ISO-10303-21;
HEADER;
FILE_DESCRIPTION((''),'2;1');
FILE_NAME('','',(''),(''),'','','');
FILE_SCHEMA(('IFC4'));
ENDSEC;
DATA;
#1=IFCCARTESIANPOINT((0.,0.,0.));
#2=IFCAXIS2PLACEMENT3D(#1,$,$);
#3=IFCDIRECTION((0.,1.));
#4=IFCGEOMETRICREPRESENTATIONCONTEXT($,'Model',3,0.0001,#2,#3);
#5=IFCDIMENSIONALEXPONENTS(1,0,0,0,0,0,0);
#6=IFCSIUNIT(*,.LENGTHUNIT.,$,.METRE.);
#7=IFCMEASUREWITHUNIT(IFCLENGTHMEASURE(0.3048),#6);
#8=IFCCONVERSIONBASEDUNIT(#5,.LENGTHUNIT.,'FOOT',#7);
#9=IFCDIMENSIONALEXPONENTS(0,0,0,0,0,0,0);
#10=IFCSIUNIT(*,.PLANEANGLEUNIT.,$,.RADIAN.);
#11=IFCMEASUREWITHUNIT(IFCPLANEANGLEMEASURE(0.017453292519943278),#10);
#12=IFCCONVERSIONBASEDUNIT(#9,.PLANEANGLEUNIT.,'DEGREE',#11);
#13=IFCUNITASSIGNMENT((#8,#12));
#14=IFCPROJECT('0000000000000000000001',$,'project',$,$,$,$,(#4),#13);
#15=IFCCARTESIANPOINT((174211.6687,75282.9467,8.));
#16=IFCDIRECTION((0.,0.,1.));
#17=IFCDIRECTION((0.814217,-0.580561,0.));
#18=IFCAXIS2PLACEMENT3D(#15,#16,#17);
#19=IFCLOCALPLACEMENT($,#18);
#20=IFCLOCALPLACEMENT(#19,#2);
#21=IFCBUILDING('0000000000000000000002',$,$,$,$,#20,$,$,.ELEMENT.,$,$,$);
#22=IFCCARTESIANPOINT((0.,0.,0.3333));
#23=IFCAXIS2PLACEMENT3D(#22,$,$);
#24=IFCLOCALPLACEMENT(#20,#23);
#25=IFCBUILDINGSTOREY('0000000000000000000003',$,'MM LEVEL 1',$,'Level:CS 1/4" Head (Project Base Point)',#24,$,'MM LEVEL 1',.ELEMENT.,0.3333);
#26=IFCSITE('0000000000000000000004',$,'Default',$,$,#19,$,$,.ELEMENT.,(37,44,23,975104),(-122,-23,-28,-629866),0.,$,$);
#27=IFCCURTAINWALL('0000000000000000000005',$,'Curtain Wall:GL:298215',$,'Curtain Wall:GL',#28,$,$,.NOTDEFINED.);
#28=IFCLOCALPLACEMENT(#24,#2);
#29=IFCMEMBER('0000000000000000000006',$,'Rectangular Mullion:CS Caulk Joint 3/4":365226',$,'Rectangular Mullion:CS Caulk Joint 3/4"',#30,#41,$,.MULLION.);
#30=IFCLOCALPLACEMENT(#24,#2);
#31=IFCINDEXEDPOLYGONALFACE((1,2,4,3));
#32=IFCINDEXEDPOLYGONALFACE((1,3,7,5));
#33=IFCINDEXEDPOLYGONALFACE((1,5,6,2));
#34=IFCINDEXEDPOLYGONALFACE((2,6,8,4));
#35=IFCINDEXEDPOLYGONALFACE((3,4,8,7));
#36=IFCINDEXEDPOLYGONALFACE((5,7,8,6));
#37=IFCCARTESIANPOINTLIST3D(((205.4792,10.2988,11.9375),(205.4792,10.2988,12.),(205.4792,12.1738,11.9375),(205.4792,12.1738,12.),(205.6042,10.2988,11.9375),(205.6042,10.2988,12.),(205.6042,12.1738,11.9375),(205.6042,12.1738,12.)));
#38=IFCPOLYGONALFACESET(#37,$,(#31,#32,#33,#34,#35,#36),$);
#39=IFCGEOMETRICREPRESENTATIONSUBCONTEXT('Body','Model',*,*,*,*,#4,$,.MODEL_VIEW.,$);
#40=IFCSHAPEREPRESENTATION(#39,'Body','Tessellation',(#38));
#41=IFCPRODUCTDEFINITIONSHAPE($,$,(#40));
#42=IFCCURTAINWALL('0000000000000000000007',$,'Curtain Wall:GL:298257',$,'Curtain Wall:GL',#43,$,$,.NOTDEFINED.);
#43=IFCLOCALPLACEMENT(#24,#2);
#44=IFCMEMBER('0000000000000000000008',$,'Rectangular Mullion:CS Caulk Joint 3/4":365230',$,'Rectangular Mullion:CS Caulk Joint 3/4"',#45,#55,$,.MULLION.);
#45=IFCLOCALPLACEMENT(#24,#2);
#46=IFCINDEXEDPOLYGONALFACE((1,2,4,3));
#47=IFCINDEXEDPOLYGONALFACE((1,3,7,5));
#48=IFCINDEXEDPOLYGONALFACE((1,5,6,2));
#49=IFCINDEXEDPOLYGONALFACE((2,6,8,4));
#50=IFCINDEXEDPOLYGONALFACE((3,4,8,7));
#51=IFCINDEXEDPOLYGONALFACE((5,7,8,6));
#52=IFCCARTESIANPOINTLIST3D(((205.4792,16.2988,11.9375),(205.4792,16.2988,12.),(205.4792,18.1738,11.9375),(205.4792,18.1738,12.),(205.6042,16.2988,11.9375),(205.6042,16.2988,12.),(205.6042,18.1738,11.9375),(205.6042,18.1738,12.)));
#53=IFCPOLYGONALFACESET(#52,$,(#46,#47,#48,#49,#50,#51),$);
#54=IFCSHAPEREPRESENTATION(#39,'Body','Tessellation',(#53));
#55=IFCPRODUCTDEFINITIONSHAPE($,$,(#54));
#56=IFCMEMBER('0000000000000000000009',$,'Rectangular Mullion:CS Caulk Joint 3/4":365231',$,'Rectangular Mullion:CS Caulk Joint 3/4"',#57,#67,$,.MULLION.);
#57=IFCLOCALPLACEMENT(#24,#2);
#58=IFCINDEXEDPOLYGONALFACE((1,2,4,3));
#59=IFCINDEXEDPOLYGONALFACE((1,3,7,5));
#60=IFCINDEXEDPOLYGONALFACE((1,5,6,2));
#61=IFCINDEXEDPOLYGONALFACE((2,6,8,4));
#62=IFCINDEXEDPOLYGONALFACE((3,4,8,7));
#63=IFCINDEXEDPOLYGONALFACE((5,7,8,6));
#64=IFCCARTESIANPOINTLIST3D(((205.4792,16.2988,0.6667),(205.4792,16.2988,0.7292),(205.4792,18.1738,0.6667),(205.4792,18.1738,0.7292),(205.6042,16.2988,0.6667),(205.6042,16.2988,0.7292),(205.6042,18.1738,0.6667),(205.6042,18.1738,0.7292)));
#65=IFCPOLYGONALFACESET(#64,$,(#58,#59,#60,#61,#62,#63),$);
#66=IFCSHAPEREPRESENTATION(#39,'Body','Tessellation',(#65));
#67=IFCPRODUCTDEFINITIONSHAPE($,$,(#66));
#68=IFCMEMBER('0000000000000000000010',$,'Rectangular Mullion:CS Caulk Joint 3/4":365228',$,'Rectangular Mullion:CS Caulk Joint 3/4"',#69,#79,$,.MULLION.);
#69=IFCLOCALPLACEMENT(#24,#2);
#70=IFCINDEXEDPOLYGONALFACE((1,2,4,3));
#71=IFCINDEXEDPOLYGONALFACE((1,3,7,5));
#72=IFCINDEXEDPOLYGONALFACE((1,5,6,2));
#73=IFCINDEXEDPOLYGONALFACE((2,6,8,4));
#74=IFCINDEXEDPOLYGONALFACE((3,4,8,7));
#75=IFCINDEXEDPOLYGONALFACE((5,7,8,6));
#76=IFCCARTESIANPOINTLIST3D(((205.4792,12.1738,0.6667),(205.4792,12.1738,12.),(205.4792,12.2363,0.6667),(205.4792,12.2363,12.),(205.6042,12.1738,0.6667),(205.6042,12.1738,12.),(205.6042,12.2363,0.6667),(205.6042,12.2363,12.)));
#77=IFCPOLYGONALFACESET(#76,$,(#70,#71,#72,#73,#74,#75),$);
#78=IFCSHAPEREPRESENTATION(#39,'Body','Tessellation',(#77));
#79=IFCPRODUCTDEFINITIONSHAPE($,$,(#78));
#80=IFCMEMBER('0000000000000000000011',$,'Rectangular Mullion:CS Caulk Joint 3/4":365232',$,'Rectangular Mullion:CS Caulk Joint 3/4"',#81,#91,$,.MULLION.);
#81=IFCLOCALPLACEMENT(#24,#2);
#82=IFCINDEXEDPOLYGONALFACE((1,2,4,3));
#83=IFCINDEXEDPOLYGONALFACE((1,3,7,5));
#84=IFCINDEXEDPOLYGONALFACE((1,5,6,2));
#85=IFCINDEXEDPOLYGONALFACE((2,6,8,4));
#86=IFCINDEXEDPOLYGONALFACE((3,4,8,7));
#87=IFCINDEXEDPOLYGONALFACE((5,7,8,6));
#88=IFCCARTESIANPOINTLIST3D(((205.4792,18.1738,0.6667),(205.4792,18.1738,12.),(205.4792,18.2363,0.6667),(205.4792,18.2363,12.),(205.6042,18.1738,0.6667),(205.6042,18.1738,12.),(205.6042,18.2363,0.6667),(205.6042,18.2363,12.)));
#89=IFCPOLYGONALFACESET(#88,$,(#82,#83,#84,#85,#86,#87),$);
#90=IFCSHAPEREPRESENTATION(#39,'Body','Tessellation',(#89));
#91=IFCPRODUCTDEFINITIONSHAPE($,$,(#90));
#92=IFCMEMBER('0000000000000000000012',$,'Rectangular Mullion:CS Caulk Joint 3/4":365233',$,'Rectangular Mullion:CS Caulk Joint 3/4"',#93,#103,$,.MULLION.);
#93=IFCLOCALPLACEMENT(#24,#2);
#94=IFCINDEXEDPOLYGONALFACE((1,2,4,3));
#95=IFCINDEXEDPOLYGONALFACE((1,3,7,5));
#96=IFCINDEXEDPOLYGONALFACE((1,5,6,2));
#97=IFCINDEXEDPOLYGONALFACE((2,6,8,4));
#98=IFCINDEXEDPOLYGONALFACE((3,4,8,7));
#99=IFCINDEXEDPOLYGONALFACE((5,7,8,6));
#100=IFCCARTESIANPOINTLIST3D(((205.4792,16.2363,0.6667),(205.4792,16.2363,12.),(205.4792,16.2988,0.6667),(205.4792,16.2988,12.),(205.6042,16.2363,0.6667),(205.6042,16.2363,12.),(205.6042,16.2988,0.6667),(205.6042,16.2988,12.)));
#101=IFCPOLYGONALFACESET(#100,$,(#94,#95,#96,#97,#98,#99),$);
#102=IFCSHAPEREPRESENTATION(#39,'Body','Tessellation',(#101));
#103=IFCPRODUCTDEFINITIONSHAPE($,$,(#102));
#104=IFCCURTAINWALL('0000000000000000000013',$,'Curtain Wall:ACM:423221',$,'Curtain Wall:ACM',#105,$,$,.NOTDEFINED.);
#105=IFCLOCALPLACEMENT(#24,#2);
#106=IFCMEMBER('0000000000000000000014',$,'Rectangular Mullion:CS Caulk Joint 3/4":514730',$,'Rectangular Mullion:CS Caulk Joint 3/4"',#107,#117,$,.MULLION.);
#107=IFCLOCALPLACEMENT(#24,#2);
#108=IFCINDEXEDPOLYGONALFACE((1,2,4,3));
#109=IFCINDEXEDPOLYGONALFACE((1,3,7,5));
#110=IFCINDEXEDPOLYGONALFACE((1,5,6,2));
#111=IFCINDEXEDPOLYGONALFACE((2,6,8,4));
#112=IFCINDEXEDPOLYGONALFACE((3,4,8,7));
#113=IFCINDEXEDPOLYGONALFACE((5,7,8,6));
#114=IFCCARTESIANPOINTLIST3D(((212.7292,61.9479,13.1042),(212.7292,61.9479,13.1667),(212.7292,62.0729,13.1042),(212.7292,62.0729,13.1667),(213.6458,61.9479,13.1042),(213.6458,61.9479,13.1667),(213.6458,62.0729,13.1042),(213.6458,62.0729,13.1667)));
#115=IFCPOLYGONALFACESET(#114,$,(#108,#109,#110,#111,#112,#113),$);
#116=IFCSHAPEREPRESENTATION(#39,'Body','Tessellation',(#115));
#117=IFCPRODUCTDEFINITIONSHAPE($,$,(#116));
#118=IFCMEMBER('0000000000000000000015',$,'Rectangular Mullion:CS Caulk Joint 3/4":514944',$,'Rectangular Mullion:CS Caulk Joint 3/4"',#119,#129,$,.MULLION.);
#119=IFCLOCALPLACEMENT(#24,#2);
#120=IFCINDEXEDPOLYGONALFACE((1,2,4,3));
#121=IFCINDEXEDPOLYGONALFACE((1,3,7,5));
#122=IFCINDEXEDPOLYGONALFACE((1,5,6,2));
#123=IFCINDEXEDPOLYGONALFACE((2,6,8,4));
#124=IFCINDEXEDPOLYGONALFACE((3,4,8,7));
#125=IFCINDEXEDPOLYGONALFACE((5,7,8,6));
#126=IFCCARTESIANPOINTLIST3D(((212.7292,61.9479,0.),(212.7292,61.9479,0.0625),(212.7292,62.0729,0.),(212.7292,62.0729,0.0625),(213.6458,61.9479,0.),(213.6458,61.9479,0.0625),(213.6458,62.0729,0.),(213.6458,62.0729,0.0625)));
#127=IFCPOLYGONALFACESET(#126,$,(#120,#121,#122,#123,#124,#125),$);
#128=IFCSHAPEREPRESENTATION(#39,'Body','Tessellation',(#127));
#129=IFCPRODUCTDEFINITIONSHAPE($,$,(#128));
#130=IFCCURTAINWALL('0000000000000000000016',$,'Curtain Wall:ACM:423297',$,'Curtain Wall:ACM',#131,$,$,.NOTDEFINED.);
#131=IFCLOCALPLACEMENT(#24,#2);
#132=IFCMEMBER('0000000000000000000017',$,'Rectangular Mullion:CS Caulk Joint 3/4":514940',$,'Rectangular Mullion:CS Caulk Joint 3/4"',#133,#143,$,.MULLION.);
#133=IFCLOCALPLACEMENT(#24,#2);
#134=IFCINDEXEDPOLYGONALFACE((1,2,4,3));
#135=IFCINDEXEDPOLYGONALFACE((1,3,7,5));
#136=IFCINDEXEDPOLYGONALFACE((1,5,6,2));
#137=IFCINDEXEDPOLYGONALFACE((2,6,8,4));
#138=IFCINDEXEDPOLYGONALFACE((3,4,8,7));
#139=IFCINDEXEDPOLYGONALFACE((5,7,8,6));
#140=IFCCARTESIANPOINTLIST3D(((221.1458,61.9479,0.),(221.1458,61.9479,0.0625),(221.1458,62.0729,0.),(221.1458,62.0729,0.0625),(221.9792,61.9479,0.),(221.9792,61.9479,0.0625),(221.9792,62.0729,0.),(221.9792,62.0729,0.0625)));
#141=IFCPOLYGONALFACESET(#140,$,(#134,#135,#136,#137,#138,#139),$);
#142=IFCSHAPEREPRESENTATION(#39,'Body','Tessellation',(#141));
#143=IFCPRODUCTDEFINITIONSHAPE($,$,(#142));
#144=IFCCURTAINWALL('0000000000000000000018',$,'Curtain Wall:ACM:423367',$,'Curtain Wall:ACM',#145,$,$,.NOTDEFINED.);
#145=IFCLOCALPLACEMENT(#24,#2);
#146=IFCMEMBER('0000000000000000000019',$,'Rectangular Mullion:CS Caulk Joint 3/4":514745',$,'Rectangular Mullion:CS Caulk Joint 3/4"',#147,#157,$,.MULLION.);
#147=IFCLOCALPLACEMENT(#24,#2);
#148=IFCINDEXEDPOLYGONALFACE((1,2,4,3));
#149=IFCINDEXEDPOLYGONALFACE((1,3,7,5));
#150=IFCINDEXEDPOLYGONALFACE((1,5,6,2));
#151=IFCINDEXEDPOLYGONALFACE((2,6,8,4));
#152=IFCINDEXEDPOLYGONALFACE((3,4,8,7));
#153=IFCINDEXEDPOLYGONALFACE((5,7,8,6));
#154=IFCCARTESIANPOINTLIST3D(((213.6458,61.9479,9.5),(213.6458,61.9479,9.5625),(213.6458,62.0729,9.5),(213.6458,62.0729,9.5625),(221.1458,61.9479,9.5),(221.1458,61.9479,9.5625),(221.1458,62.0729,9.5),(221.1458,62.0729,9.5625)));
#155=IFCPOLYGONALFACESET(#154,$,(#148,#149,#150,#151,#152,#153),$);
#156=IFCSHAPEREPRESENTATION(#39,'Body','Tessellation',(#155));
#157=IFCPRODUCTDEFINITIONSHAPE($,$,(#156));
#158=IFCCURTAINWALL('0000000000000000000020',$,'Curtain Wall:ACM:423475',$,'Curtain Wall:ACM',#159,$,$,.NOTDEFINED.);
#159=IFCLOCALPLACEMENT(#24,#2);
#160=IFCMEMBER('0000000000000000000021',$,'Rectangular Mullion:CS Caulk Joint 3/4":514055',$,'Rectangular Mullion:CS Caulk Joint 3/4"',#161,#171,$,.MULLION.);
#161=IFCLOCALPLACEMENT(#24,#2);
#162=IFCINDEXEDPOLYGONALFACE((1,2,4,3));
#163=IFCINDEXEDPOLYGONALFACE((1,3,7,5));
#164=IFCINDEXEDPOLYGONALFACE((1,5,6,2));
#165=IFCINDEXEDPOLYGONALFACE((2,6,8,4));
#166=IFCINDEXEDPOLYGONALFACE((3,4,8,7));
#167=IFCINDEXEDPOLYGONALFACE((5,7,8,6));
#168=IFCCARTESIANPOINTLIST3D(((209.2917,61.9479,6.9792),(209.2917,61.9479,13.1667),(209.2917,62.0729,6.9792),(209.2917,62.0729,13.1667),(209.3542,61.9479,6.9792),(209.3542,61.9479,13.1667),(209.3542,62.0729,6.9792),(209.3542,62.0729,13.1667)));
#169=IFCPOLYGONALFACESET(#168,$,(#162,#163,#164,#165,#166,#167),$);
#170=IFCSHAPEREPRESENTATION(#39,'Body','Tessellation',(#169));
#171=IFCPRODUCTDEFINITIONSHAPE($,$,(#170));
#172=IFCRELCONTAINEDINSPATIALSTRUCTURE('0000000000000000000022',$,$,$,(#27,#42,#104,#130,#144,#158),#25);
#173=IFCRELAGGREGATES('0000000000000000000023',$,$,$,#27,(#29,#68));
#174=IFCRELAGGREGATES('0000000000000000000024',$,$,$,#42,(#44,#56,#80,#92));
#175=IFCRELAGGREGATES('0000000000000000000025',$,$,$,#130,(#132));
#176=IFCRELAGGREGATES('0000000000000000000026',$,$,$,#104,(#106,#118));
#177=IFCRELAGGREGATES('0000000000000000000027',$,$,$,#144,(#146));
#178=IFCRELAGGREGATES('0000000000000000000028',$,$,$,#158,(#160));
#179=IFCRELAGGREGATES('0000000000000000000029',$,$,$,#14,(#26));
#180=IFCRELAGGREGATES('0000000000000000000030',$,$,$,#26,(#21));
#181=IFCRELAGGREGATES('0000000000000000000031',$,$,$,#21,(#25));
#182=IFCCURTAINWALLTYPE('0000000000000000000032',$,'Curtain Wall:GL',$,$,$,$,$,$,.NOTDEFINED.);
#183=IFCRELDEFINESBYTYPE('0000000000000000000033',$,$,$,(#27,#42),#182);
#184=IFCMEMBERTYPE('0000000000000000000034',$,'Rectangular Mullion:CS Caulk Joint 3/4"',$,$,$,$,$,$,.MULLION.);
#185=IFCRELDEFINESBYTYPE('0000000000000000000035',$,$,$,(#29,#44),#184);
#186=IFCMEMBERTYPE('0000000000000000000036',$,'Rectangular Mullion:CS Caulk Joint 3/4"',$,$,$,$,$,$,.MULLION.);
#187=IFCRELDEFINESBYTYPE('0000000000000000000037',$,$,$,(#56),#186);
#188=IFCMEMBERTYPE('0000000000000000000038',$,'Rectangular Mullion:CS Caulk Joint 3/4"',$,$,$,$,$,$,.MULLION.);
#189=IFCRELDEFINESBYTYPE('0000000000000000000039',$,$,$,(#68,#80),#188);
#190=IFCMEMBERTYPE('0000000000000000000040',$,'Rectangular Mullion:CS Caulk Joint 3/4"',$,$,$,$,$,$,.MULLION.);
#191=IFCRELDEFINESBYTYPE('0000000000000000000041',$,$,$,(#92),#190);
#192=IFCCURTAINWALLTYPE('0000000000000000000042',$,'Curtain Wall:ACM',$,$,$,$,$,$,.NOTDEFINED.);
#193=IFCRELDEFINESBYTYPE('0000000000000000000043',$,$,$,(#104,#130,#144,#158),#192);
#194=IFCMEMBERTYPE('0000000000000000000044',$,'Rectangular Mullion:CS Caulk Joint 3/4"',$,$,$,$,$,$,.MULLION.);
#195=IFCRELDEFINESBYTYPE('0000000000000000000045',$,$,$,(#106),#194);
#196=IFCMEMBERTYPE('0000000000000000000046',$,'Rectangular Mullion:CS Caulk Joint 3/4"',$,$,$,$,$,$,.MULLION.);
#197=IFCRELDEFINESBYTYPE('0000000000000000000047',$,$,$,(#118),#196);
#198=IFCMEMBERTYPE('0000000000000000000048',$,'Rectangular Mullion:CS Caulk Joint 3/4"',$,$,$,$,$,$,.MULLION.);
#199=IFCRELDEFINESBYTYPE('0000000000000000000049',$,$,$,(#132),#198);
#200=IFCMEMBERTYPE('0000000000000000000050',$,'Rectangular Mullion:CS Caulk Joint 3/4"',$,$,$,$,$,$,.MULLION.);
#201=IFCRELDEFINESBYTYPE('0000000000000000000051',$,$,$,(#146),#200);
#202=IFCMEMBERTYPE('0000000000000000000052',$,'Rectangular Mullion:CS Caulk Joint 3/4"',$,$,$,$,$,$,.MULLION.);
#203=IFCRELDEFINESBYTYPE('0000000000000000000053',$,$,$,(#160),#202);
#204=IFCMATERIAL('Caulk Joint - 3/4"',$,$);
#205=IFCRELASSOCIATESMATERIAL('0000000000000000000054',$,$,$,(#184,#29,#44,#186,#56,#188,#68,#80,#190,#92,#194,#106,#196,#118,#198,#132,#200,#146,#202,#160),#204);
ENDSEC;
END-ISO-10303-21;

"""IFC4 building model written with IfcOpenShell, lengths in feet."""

from ifc_helpers import new_model, entity, si_unit, converted_unit, direction, frame, origin, place, context, subcontext, project, spatial, indexed_curve, outline, extrude, source, transform, mapped, material, type_object, type_shapes, element, aggregate, save


model = new_model("IFC4")

# Units and contexts
model_context = context("Model", 3, precision=0.0001, world=origin(), true_north=direction((0.0, 1.0)))
body_context = subcontext(model_context, "Body", "Model", "MODEL_VIEW")
ifc_project = project(units=[converted_unit("LENGTHUNIT", "FOOT", entity("IfcLengthMeasure", 0.3048), si_unit("LENGTHUNIT", "METRE"), dimensions=[1, 0, 0, 0, 0, 0, 0]), converted_unit("PLANEANGLEUNIT", "DEGREE", entity("IfcPlaneAngleMeasure", 0.017453292519943278), si_unit("PLANEANGLEUNIT", "RADIAN"), dimensions=[0, 0, 0, 0, 0, 0, 0])], contexts=[model_context])

# Site, building, storey
site_placement = place(None, frame((174211.6687, 75282.9467, 8.0), z_axis=(0.0, 0.0, 1.0), x_axis=(0.814217, -0.580561, 0.0)))
site = spatial("IfcSite", under=ifc_project, at=site_placement, Name="Default", CompositionType="ELEMENT", RefLatitude=(37, 44, 23, 975104), RefLongitude=(-122, -23, -28, -629866), RefElevation=0.0)
building_placement = place(site_placement, origin())
building = spatial("IfcBuilding", under=site, at=building_placement, CompositionType="ELEMENT")
storey_placement = place(building_placement, frame((0.0, 0.0, 0.3333)))
storey = spatial("IfcBuildingStorey", under=building, at=storey_placement, Name="MM LEVEL 1", ObjectType="Level:CS 1/4\" Head (Project Base Point)", LongName="MM LEVEL 1", CompositionType="ELEMENT", Elevation=0.3333)

# Curtain wall, member
curtain_wall_type_1 = type_object("IfcCurtainWallType", Name="Curtain Wall:GL", PredefinedType="NOTDEFINED")
curtain_wall_1_placement = place(storey_placement, frame((0.0, 0.0, -0.3333)))
curtain_wall_1 = element("IfcCurtainWall", 1, at=curtain_wall_1_placement, inside=storey, type_object=curtain_wall_type_1, Name="Curtain Wall:GL:298215", ObjectType="Curtain Wall:GL", PredefinedType="NOTDEFINED")
ifc_material_1 = material(Name="Caulk Joint - 3/4\"")
member_type_1 = type_object("IfcMemberType", Name="Rectangular Mullion:CS Caulk Joint 3/4\"", PredefinedType="MULLION", material=ifc_material_1)
shared_shape_1 = source(origin(), body_context, "Body", "SweptSolid", [
    extrude(outline(indexed_curve([(-0.0625, -0.0312), (0.0625, -0.0312), (0.0625, 0.0312), (-0.0625, 0.0312), (-0.0625, -0.0312)], self_intersect=False)), frame((-0.0312, 0.0625, -1.875), z_axis=(0.0, 0.0, 1.0), x_axis=(0.0, -1.0, 0.0)), (0.0, 0.0, 1.0), 1.875),
])
type_shapes(member_type_1, [shared_shape_1])
member_1_placement = place(curtain_wall_1_placement, frame((205.4792, 12.1738, 12.3333), z_axis=(0.0, 1.0, 0.0), x_axis=(0.0, 0.0, 1.0)))
member_1 = element("IfcMember", 2, at=member_1_placement, type_object=member_type_1, material=ifc_material_1, Name="Rectangular Mullion:CS Caulk Joint 3/4\":365226", ObjectType="Rectangular Mullion:CS Caulk Joint 3/4\"", PredefinedType="MULLION", context=body_context, shape_type="MappedRepresentation", body=[
    mapped(shared_shape_1, transform((0.0, 0.0, 0.0), scale=1.0)),
])

# Curtain wall, members
curtain_wall_2_placement = place(storey_placement, frame((0.0, 0.0, -0.3333)))
curtain_wall_2 = element("IfcCurtainWall", 3, at=curtain_wall_2_placement, inside=storey, type_object=curtain_wall_type_1, Name="Curtain Wall:GL:298257", ObjectType="Curtain Wall:GL", PredefinedType="NOTDEFINED")
member_2_placement = place(curtain_wall_2_placement, frame((205.4792, 18.1738, 12.3333), z_axis=(0.0, 1.0, 0.0), x_axis=(0.0, 0.0, 1.0)))
member_2 = element("IfcMember", 4, at=member_2_placement, type_object=member_type_1, material=ifc_material_1, Name="Rectangular Mullion:CS Caulk Joint 3/4\":365230", ObjectType="Rectangular Mullion:CS Caulk Joint 3/4\"", PredefinedType="MULLION", context=body_context, shape_type="MappedRepresentation", body=[
    mapped(shared_shape_1, transform((0.0, 0.0, 0.0), scale=1.0)),
])
member_type_2 = type_object("IfcMemberType", Name="Rectangular Mullion:CS Caulk Joint 3/4\"", PredefinedType="MULLION", material=ifc_material_1)
shared_shape_2 = source(origin(), body_context, "Body", "SweptSolid", [
    extrude(outline(indexed_curve([(-0.0312, -0.0625), (0.0312, -0.0625), (0.0312, 0.0625), (-0.0312, 0.0625), (-0.0312, -0.0625)], self_intersect=False)), frame((-0.0312, 0.0625, -1.875), z_axis=(0.0, 0.0, 1.0), x_axis=(-1.0, 0.0, 0.0)), (0.0, 0.0, 1.0), 1.875),
])
type_shapes(member_type_2, [shared_shape_2])
member_3_placement = place(curtain_wall_2_placement, frame((205.4792, 16.2988, 1.0), z_axis=(0.0, -1.0, 0.0), x_axis=(0.0, 0.0, -1.0)))
member_3 = element("IfcMember", 5, at=member_3_placement, type_object=member_type_2, material=ifc_material_1, Name="Rectangular Mullion:CS Caulk Joint 3/4\":365231", ObjectType="Rectangular Mullion:CS Caulk Joint 3/4\"", PredefinedType="MULLION", context=body_context, shape_type="MappedRepresentation", body=[
    mapped(shared_shape_2, transform((0.0, 0.0, 0.0), scale=1.0)),
])

# Members
member_type_3 = type_object("IfcMemberType", Name="Rectangular Mullion:CS Caulk Joint 3/4\"", PredefinedType="MULLION", material=ifc_material_1)
shared_shape_3 = source(origin(), body_context, "Body", "SweptSolid", [
    extrude(outline(indexed_curve([(-0.0625, -0.0312), (0.0625, -0.0312), (0.0625, 0.0312), (-0.0625, 0.0312), (-0.0625, -0.0312)], self_intersect=False)), frame((-0.0312, 0.0625, -11.3333), z_axis=(0.0, 0.0, 1.0), x_axis=(0.0, -1.0, 0.0)), (0.0, 0.0, 1.0), 11.3333),
])
type_shapes(member_type_3, [shared_shape_3])
member_4_placement = place(curtain_wall_1_placement, frame((205.4792, 12.2363, 1.0), z_axis=(0.0, 0.0, -1.0), x_axis=(0.0, 1.0, 0.0)))
member_4 = element("IfcMember", 6, at=member_4_placement, type_object=member_type_3, material=ifc_material_1, Name="Rectangular Mullion:CS Caulk Joint 3/4\":365228", ObjectType="Rectangular Mullion:CS Caulk Joint 3/4\"", PredefinedType="MULLION", context=body_context, shape_type="MappedRepresentation", body=[
    mapped(shared_shape_3, transform((0.0, 0.0, 0.0), scale=1.0)),
])
aggregate(curtain_wall_1, [member_1, member_4])
member_5_placement = place(curtain_wall_2_placement, frame((205.4792, 18.2363, 1.0), z_axis=(0.0, 0.0, -1.0), x_axis=(0.0, 1.0, 0.0)))
member_5 = element("IfcMember", 7, at=member_5_placement, type_object=member_type_3, material=ifc_material_1, Name="Rectangular Mullion:CS Caulk Joint 3/4\":365232", ObjectType="Rectangular Mullion:CS Caulk Joint 3/4\"", PredefinedType="MULLION", context=body_context, shape_type="MappedRepresentation", body=[
    mapped(shared_shape_3, transform((0.0, 0.0, 0.0), scale=1.0)),
])
member_type_4 = type_object("IfcMemberType", Name="Rectangular Mullion:CS Caulk Joint 3/4\"", PredefinedType="MULLION", material=ifc_material_1)
shared_shape_4 = source(origin(), body_context, "Body", "SweptSolid", [
    extrude(outline(indexed_curve([(-0.0312, -0.0625), (0.0312, -0.0625), (0.0312, 0.0625), (-0.0312, 0.0625), (-0.0312, -0.0625)], self_intersect=False)), frame((-0.0312, 0.0625, -11.3333), z_axis=(0.0, 0.0, 1.0), x_axis=(-1.0, 0.0, 0.0)), (0.0, 0.0, 1.0), 11.3333),
])
type_shapes(member_type_4, [shared_shape_4])
member_6_placement = place(curtain_wall_2_placement, frame((205.4792, 16.2363, 12.3333), z_axis=(0.0, 0.0, 1.0), x_axis=(0.0, -1.0, 0.0)))
member_6 = element("IfcMember", 8, at=member_6_placement, type_object=member_type_4, material=ifc_material_1, Name="Rectangular Mullion:CS Caulk Joint 3/4\":365233", ObjectType="Rectangular Mullion:CS Caulk Joint 3/4\"", PredefinedType="MULLION", context=body_context, shape_type="MappedRepresentation", body=[
    mapped(shared_shape_4, transform((0.0, 0.0, 0.0), scale=1.0)),
])
aggregate(curtain_wall_2, [member_2, member_3, member_5, member_6])

# Curtain wall, members
curtain_wall_type_2 = type_object("IfcCurtainWallType", Name="Curtain Wall:ACM", PredefinedType="NOTDEFINED")
curtain_wall_3_placement = place(storey_placement, frame((0.0, 0.0, -0.3333)))
curtain_wall_3 = element("IfcCurtainWall", 9, at=curtain_wall_3_placement, inside=storey, type_object=curtain_wall_type_2, Name="Curtain Wall:ACM:423221", ObjectType="Curtain Wall:ACM", PredefinedType="NOTDEFINED")
member_type_5 = type_object("IfcMemberType", Name="Rectangular Mullion:CS Caulk Joint 3/4\"", PredefinedType="MULLION", material=ifc_material_1)
shared_shape_5 = source(origin(), body_context, "Body", "SweptSolid", [
    extrude(outline(indexed_curve([(-0.4583, -0.0625), (0.4583, -0.0625), (0.4583, 0.0625), (-0.4583, 0.0625), (-0.4583, -0.0625)], self_intersect=False)), frame((-0.0625, 0.0625, -0.4583), z_axis=(1.0, 0.0, 0.0), x_axis=(0.0, 0.0, -1.0)), (0.0, 0.0, 1.0), 0.0625),
])
type_shapes(member_type_5, [shared_shape_5])
member_7_placement = place(curtain_wall_3_placement, frame((213.6458, 62.0729, 13.5), z_axis=(1.0, 0.0, 0.0), x_axis=(0.0, 0.0, 1.0)))
member_7 = element("IfcMember", 10, at=member_7_placement, type_object=member_type_5, material=ifc_material_1, Name="Rectangular Mullion:CS Caulk Joint 3/4\":514730", ObjectType="Rectangular Mullion:CS Caulk Joint 3/4\"", PredefinedType="MULLION", context=body_context, shape_type="MappedRepresentation", body=[
    mapped(shared_shape_5, transform((0.0, 0.0, 0.0), scale=1.0)),
])
member_type_6 = type_object("IfcMemberType", Name="Rectangular Mullion:CS Caulk Joint 3/4\"", PredefinedType="MULLION", material=ifc_material_1)
shared_shape_6 = source(origin(), body_context, "Body", "SweptSolid", [
    extrude(outline(indexed_curve([(-0.0312, -0.0625), (0.0312, -0.0625), (0.0312, 0.0625), (-0.0312, 0.0625), (-0.0312, -0.0625)], self_intersect=False)), frame((-0.0312, 0.0625, -0.9167), z_axis=(0.0, 0.0, 1.0), x_axis=(-1.0, 0.0, 0.0)), (0.0, 0.0, 1.0), 0.9167),
])
type_shapes(member_type_6, [shared_shape_6])
member_8_placement = place(curtain_wall_3_placement, frame((212.7292, 62.0729, 0.3333), z_axis=(-1.0, 0.0, 0.0), x_axis=(0.0, 0.0, -1.0)))
member_8 = element("IfcMember", 11, at=member_8_placement, type_object=member_type_6, material=ifc_material_1, Name="Rectangular Mullion:CS Caulk Joint 3/4\":514944", ObjectType="Rectangular Mullion:CS Caulk Joint 3/4\"", PredefinedType="MULLION", context=body_context, shape_type="MappedRepresentation", body=[
    mapped(shared_shape_6, transform((0.0, 0.0, 0.0), scale=1.0)),
])

# Curtain walls, members
curtain_wall_4_placement = place(storey_placement, frame((0.0, 0.0, -0.3333)))
curtain_wall_4 = element("IfcCurtainWall", 12, at=curtain_wall_4_placement, inside=storey, type_object=curtain_wall_type_2, Name="Curtain Wall:ACM:423297", ObjectType="Curtain Wall:ACM", PredefinedType="NOTDEFINED")
member_type_7 = type_object("IfcMemberType", Name="Rectangular Mullion:CS Caulk Joint 3/4\"", PredefinedType="MULLION", material=ifc_material_1)
shared_shape_7 = source(origin(), body_context, "Body", "SweptSolid", [
    extrude(outline(indexed_curve([(-0.0312, -0.0625), (0.0312, -0.0625), (0.0312, 0.0625), (-0.0312, 0.0625), (-0.0312, -0.0625)], self_intersect=False)), frame((-0.0312, 0.0625, -0.8333), z_axis=(0.0, 0.0, 1.0), x_axis=(-1.0, 0.0, 0.0)), (0.0, 0.0, 1.0), 0.8333),
])
type_shapes(member_type_7, [shared_shape_7])
member_9_placement = place(curtain_wall_4_placement, frame((221.1458, 62.0729, 0.3333), z_axis=(-1.0, 0.0, 0.0), x_axis=(0.0, 0.0, -1.0)))
member_9 = element("IfcMember", 13, at=member_9_placement, type_object=member_type_7, material=ifc_material_1, Name="Rectangular Mullion:CS Caulk Joint 3/4\":514940", ObjectType="Rectangular Mullion:CS Caulk Joint 3/4\"", PredefinedType="MULLION", context=body_context, shape_type="MappedRepresentation", body=[
    mapped(shared_shape_7, transform((0.0, 0.0, 0.0), scale=1.0)),
])
aggregate(curtain_wall_4, [member_9])
curtain_wall_5_placement = place(storey_placement, frame((0.0, 0.0, -0.3333)))
curtain_wall_5 = element("IfcCurtainWall", 14, at=curtain_wall_5_placement, inside=storey, type_object=curtain_wall_type_2, Name="Curtain Wall:ACM:423367", ObjectType="Curtain Wall:ACM", PredefinedType="NOTDEFINED")
member_type_8 = type_object("IfcMemberType", Name="Rectangular Mullion:CS Caulk Joint 3/4\"", PredefinedType="MULLION", material=ifc_material_1)
shared_shape_8 = source(origin(), body_context, "Body", "SweptSolid", [
    extrude(outline(indexed_curve([(-0.0312, -0.0625), (0.0312, -0.0625), (0.0312, 0.0625), (-0.0312, 0.0625), (-0.0312, -0.0625)], self_intersect=False)), frame((-0.0312, 0.0625, -7.5), z_axis=(0.0, 0.0, 1.0), x_axis=(-1.0, 0.0, 0.0)), (0.0, 0.0, 1.0), 7.5),
])
type_shapes(member_type_8, [shared_shape_8])
member_10_placement = place(curtain_wall_5_placement, frame((213.6458, 62.0729, 9.8333), z_axis=(-1.0, 0.0, 0.0), x_axis=(0.0, 0.0, -1.0)))
member_10 = element("IfcMember", 15, at=member_10_placement, type_object=member_type_8, material=ifc_material_1, Name="Rectangular Mullion:CS Caulk Joint 3/4\":514745", ObjectType="Rectangular Mullion:CS Caulk Joint 3/4\"", PredefinedType="MULLION", context=body_context, shape_type="MappedRepresentation", body=[
    mapped(shared_shape_8, transform((0.0, 0.0, 0.0), scale=1.0)),
])

# Curtain wall, member
curtain_wall_6_placement = place(storey_placement, frame((0.0, 0.0, -0.3333)))
curtain_wall_6 = element("IfcCurtainWall", 16, at=curtain_wall_6_placement, inside=storey, type_object=curtain_wall_type_2, Name="Curtain Wall:ACM:423475", ObjectType="Curtain Wall:ACM", PredefinedType="NOTDEFINED")
member_type_9 = type_object("IfcMemberType", Name="Rectangular Mullion:CS Caulk Joint 3/4\"", PredefinedType="MULLION", material=ifc_material_1)
shared_shape_9 = source(origin(), body_context, "Body", "SweptSolid", [
    extrude(outline(indexed_curve([(-0.0312, -0.0625), (0.0312, -0.0625), (0.0312, 0.0625), (-0.0312, 0.0625), (-0.0312, -0.0625)], self_intersect=False)), frame((-0.0312, 0.0625, -6.1875), z_axis=(0.0, 0.0, 1.0), x_axis=(-1.0, 0.0, 0.0)), (0.0, 0.0, 1.0), 6.1875),
])
type_shapes(member_type_9, [shared_shape_9])
member_11_placement = place(curtain_wall_6_placement, frame((209.2917, 62.0729, 13.5), z_axis=(0.0, 0.0, 1.0), x_axis=(-1.0, 0.0, 0.0)))
member_11 = element("IfcMember", 17, at=member_11_placement, type_object=member_type_9, material=ifc_material_1, Name="Rectangular Mullion:CS Caulk Joint 3/4\":514055", ObjectType="Rectangular Mullion:CS Caulk Joint 3/4\"", PredefinedType="MULLION", context=body_context, shape_type="MappedRepresentation", body=[
    mapped(shared_shape_9, transform((0.0, 0.0, 0.0), scale=1.0)),
])

aggregate(curtain_wall_3, [member_7, member_8])
aggregate(curtain_wall_5, [member_10])
aggregate(curtain_wall_6, [member_11])

save(model, "model.ifc")
